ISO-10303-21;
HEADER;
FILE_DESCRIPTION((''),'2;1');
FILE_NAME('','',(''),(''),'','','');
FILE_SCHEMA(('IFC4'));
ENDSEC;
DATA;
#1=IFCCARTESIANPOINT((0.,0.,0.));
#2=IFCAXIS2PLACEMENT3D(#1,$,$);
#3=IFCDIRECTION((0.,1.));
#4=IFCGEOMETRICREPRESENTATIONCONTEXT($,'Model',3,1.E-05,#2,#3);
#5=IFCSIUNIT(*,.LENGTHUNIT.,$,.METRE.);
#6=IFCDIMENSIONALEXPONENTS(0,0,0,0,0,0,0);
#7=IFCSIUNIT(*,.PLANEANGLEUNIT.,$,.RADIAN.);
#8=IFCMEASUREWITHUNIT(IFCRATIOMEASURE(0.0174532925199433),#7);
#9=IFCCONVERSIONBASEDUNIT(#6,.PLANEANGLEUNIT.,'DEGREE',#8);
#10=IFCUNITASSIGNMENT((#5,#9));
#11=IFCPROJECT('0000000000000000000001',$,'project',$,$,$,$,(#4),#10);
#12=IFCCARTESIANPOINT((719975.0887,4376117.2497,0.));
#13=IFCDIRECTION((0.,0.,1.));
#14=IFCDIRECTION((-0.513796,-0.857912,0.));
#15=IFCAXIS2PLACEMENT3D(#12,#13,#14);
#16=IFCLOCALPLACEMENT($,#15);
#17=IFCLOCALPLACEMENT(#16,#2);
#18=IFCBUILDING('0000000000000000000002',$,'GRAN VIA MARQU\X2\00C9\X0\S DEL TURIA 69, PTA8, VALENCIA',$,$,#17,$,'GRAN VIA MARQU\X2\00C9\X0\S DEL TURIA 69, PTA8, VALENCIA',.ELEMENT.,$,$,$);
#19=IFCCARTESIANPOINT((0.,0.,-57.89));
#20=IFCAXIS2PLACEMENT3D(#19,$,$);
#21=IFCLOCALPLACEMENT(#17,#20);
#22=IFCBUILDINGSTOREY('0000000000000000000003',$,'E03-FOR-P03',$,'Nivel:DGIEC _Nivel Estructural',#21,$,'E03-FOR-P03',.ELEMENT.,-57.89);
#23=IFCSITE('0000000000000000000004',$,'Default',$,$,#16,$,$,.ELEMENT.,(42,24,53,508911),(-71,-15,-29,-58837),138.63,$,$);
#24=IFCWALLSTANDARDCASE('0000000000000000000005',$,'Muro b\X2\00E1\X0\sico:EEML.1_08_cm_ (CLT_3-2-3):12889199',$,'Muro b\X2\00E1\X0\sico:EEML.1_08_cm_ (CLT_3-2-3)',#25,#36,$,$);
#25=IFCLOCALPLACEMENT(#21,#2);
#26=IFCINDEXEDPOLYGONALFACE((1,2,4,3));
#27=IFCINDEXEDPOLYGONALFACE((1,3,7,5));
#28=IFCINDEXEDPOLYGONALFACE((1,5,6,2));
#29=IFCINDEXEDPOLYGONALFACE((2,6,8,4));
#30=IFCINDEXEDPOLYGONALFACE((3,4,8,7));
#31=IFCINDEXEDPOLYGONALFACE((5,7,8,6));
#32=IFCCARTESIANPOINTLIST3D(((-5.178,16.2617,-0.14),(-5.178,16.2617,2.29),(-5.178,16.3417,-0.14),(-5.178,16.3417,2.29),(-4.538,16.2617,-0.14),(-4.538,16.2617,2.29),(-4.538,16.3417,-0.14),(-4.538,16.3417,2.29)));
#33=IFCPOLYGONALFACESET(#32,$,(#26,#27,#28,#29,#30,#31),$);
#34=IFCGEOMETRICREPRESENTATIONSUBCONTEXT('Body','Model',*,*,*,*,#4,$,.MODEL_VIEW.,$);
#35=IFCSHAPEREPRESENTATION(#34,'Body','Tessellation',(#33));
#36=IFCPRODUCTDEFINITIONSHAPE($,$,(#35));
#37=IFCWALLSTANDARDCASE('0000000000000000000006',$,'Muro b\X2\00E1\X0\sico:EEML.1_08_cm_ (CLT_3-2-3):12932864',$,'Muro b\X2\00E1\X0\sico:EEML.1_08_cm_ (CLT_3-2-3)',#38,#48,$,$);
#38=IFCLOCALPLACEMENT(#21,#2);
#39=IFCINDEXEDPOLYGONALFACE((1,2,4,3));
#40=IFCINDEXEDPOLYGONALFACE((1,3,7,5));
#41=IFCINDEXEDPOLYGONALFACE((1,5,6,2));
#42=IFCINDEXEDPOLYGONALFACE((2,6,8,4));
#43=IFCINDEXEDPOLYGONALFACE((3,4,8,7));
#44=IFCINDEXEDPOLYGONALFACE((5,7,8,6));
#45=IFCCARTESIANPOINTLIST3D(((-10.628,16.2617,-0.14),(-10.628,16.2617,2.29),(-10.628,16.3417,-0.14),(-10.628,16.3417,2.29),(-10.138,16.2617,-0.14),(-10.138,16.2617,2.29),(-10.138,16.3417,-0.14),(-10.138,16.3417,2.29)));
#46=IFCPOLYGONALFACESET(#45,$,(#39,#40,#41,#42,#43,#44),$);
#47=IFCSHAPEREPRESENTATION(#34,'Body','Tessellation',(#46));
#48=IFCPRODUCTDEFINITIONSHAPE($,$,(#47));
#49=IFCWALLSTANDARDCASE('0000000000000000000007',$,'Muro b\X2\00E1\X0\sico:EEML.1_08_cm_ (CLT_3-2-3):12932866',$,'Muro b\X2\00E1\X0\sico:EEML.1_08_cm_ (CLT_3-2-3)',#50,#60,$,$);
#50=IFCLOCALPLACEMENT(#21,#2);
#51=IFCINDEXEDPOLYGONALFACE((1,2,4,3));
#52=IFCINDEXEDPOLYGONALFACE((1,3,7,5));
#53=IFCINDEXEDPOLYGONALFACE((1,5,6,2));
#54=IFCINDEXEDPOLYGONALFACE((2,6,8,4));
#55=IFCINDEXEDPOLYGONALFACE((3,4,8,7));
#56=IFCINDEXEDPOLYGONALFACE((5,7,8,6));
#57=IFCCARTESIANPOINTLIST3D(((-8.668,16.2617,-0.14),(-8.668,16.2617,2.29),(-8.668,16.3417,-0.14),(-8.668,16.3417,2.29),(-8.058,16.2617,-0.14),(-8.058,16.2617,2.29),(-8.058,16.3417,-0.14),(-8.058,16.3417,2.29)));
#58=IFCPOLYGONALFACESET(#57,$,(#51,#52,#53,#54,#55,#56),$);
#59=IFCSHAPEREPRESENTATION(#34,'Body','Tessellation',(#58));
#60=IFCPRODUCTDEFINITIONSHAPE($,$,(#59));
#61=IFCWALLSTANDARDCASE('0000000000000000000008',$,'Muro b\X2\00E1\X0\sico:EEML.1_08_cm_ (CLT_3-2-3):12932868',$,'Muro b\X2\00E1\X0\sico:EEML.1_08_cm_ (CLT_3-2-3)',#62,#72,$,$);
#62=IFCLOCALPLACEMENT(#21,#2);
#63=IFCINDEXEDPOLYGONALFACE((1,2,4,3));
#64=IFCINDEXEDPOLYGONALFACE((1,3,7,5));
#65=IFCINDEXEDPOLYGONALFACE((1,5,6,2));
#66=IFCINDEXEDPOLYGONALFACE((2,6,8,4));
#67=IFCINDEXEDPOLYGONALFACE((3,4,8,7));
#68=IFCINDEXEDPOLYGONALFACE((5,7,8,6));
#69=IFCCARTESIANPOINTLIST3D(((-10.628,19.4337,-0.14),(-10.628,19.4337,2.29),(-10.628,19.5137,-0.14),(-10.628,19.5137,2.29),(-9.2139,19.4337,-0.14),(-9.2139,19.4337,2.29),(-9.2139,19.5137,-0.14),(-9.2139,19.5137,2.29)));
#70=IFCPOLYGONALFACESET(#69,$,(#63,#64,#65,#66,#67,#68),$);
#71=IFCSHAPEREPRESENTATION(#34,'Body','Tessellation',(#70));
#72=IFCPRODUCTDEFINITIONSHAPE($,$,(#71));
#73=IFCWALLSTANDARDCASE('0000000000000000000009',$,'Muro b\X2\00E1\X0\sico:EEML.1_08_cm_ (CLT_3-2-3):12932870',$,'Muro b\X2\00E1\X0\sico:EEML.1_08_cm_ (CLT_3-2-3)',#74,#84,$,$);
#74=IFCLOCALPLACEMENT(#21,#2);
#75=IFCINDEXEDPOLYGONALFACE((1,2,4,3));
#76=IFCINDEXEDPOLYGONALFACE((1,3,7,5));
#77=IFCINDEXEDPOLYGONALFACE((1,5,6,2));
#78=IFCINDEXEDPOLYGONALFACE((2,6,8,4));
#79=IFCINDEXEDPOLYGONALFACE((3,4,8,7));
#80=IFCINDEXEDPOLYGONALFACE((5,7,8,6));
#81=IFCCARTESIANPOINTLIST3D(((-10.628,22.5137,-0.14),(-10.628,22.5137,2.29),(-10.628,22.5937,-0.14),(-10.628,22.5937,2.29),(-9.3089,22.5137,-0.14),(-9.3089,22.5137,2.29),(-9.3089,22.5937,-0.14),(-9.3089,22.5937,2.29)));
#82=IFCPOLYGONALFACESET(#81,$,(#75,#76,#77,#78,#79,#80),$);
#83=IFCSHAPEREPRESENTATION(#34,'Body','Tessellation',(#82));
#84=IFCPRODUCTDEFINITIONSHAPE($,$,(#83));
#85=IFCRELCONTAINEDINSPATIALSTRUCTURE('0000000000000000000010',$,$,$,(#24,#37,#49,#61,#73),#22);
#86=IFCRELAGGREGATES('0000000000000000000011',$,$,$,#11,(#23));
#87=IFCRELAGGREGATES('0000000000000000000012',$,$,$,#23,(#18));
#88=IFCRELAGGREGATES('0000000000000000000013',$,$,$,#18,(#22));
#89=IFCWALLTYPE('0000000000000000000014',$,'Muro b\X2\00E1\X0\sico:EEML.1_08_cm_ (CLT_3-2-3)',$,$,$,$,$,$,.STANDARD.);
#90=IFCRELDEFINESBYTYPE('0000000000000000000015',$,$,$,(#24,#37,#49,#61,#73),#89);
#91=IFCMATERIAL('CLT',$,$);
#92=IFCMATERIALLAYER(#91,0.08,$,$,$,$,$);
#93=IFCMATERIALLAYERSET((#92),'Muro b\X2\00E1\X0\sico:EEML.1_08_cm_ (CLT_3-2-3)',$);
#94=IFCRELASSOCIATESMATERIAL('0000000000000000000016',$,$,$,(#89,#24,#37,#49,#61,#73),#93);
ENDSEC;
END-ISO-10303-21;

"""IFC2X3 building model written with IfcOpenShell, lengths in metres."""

from ifc_helpers import new_model, entity, si_unit, converted_unit, direction, frame, frame_2d, origin, place, context, subcontext, project, spatial, rectangle, extrude, material, layer, layer_set, layer_usage, type_object, element, save


model = new_model("IFC2X3")

# Units and contexts
model_context = context("Model", 3, precision=1e-05, world=origin(), true_north=direction((0.0, 1.0)))
body_context = subcontext(model_context, "Body", "Model", "MODEL_VIEW")
ifc_project = project(units=[si_unit("LENGTHUNIT", "METRE"), converted_unit("PLANEANGLEUNIT", "DEGREE", entity("IfcRatioMeasure", 0.0174532925199433), si_unit("PLANEANGLEUNIT", "RADIAN"), dimensions=[0, 0, 0, 0, 0, 0, 0])], contexts=[model_context])

# Site, building, storey
site_placement = place(None, frame((719975.0887, 4376117.2497, 0.0), z_axis=(0.0, 0.0, 1.0), x_axis=(-0.513796, -0.857912, 0.0)))
site = spatial("IfcSite", under=ifc_project, at=site_placement, Name="Default", CompositionType="ELEMENT", RefLatitude=(42, 24, 53, 508911), RefLongitude=(-71, -15, -29, -58837), RefElevation=138.63)
building_placement = place(site_placement, origin())
building = spatial("IfcBuilding", under=site, at=building_placement, Name="GRAN VIA MARQUÉS DEL TURIA 69, PTA8, VALENCIA", LongName="GRAN VIA MARQUÉS DEL TURIA 69, PTA8, VALENCIA", CompositionType="ELEMENT")
storey_placement = place(building_placement, frame((0.0, 0.0, -57.89)))
storey = spatial("IfcBuildingStorey", under=building, at=storey_placement, Name="E03-FOR-P03", ObjectType="Nivel:DGIEC _Nivel Estructural", LongName="E03-FOR-P03", CompositionType="ELEMENT", Elevation=-57.89)

# Shared definitions
ifc_material = material(Name="CLT")

# Walls
ifc_layer_1 = layer(ifc_material, 0.08)
ifc_layer_set_1 = layer_set([ifc_layer_1], Name="Muro básico:EEML.1_08_cm_ (CLT_3-2-3)")
ifc_layer_usage_1 = layer_usage(ifc_layer_set_1, "AXIS2", "NEGATIVE", 0.04)
wall_type_1 = type_object("IfcWallType", Name="Muro básico:EEML.1_08_cm_ (CLT_3-2-3)", PredefinedType="STANDARD", material=ifc_layer_set_1)
wall_1_placement = place(storey_placement, frame((-4.538, 16.3017, -0.14), z_axis=(0.0, 0.0, 1.0), x_axis=(-1.0, 0.0, 0.0)))
element("IfcWallStandardCase", 1, at=wall_1_placement, inside=storey, type_object=wall_type_1, material=ifc_layer_usage_1, Name="Muro básico:EEML.1_08_cm_ (CLT_3-2-3):12889199", ObjectType="Muro básico:EEML.1_08_cm_ (CLT_3-2-3)", context=body_context, shape_type="SweptSolid", body=[
    extrude(rectangle(XDim=0.64, YDim=0.08, at=frame_2d((0.32, 0.0), x_axis=(-1.0, 0.0))), origin(), (0.0, 0.0, 1.0), 2.43),
])
ifc_layer_usage_2 = layer_usage(ifc_layer_set_1, "AXIS2", "NEGATIVE", 0.04)
wall_2_placement = place(storey_placement, frame((-10.138, 16.3017, -0.14), z_axis=(0.0, 0.0, 1.0), x_axis=(-1.0, 0.0, 0.0)))
element("IfcWallStandardCase", 2, at=wall_2_placement, inside=storey, type_object=wall_type_1, material=ifc_layer_usage_2, Name="Muro básico:EEML.1_08_cm_ (CLT_3-2-3):12932864", ObjectType="Muro básico:EEML.1_08_cm_ (CLT_3-2-3)", context=body_context, shape_type="SweptSolid", body=[
    extrude(rectangle(XDim=0.49, YDim=0.08, at=frame_2d((0.245, 0.0), x_axis=(-1.0, 0.0))), origin(), (0.0, 0.0, 1.0), 2.43),
])
ifc_layer_usage_3 = layer_usage(ifc_layer_set_1, "AXIS2", "NEGATIVE", 0.04)
wall_3_placement = place(storey_placement, frame((-8.058, 16.3017, -0.14), z_axis=(0.0, 0.0, 1.0), x_axis=(-1.0, 0.0, 0.0)))
element("IfcWallStandardCase", 3, at=wall_3_placement, inside=storey, type_object=wall_type_1, material=ifc_layer_usage_3, Name="Muro básico:EEML.1_08_cm_ (CLT_3-2-3):12932866", ObjectType="Muro básico:EEML.1_08_cm_ (CLT_3-2-3)", context=body_context, shape_type="SweptSolid", body=[
    extrude(rectangle(XDim=0.61, YDim=0.08, at=frame_2d((0.305, 0.0), x_axis=(-1.0, 0.0))), origin(), (0.0, 0.0, 1.0), 2.43),
])
ifc_layer_usage_4 = layer_usage(ifc_layer_set_1, "AXIS2", "NEGATIVE", 0.04)
wall_4_placement = place(storey_placement, frame((-9.2139, 19.4737, -0.14), z_axis=(0.0, 0.0, 1.0), x_axis=(-1.0, 0.0, 0.0)))
element("IfcWallStandardCase", 4, at=wall_4_placement, inside=storey, type_object=wall_type_1, material=ifc_layer_usage_4, Name="Muro básico:EEML.1_08_cm_ (CLT_3-2-3):12932868", ObjectType="Muro básico:EEML.1_08_cm_ (CLT_3-2-3)", context=body_context, shape_type="SweptSolid", body=[
    extrude(rectangle(XDim=1.4142, YDim=0.08, at=frame_2d((0.7071, 0.0), x_axis=(-1.0, 0.0))), origin(), (0.0, 0.0, 1.0), 2.43),
])
ifc_layer_usage_5 = layer_usage(ifc_layer_set_1, "AXIS2", "NEGATIVE", 0.04)
wall_5_placement = place(storey_placement, frame((-9.3089, 22.5537, -0.14), z_axis=(0.0, 0.0, 1.0), x_axis=(-1.0, 0.0, 0.0)))
element("IfcWallStandardCase", 5, at=wall_5_placement, inside=storey, type_object=wall_type_1, material=ifc_layer_usage_5, Name="Muro básico:EEML.1_08_cm_ (CLT_3-2-3):12932870", ObjectType="Muro básico:EEML.1_08_cm_ (CLT_3-2-3)", context=body_context, shape_type="SweptSolid", body=[
    extrude(rectangle(XDim=1.3192, YDim=0.08, at=frame_2d((0.6596, 0.0), x_axis=(-1.0, 0.0))), origin(), (0.0, 0.0, 1.0), 2.43),
])

save(model, "model.ifc")
